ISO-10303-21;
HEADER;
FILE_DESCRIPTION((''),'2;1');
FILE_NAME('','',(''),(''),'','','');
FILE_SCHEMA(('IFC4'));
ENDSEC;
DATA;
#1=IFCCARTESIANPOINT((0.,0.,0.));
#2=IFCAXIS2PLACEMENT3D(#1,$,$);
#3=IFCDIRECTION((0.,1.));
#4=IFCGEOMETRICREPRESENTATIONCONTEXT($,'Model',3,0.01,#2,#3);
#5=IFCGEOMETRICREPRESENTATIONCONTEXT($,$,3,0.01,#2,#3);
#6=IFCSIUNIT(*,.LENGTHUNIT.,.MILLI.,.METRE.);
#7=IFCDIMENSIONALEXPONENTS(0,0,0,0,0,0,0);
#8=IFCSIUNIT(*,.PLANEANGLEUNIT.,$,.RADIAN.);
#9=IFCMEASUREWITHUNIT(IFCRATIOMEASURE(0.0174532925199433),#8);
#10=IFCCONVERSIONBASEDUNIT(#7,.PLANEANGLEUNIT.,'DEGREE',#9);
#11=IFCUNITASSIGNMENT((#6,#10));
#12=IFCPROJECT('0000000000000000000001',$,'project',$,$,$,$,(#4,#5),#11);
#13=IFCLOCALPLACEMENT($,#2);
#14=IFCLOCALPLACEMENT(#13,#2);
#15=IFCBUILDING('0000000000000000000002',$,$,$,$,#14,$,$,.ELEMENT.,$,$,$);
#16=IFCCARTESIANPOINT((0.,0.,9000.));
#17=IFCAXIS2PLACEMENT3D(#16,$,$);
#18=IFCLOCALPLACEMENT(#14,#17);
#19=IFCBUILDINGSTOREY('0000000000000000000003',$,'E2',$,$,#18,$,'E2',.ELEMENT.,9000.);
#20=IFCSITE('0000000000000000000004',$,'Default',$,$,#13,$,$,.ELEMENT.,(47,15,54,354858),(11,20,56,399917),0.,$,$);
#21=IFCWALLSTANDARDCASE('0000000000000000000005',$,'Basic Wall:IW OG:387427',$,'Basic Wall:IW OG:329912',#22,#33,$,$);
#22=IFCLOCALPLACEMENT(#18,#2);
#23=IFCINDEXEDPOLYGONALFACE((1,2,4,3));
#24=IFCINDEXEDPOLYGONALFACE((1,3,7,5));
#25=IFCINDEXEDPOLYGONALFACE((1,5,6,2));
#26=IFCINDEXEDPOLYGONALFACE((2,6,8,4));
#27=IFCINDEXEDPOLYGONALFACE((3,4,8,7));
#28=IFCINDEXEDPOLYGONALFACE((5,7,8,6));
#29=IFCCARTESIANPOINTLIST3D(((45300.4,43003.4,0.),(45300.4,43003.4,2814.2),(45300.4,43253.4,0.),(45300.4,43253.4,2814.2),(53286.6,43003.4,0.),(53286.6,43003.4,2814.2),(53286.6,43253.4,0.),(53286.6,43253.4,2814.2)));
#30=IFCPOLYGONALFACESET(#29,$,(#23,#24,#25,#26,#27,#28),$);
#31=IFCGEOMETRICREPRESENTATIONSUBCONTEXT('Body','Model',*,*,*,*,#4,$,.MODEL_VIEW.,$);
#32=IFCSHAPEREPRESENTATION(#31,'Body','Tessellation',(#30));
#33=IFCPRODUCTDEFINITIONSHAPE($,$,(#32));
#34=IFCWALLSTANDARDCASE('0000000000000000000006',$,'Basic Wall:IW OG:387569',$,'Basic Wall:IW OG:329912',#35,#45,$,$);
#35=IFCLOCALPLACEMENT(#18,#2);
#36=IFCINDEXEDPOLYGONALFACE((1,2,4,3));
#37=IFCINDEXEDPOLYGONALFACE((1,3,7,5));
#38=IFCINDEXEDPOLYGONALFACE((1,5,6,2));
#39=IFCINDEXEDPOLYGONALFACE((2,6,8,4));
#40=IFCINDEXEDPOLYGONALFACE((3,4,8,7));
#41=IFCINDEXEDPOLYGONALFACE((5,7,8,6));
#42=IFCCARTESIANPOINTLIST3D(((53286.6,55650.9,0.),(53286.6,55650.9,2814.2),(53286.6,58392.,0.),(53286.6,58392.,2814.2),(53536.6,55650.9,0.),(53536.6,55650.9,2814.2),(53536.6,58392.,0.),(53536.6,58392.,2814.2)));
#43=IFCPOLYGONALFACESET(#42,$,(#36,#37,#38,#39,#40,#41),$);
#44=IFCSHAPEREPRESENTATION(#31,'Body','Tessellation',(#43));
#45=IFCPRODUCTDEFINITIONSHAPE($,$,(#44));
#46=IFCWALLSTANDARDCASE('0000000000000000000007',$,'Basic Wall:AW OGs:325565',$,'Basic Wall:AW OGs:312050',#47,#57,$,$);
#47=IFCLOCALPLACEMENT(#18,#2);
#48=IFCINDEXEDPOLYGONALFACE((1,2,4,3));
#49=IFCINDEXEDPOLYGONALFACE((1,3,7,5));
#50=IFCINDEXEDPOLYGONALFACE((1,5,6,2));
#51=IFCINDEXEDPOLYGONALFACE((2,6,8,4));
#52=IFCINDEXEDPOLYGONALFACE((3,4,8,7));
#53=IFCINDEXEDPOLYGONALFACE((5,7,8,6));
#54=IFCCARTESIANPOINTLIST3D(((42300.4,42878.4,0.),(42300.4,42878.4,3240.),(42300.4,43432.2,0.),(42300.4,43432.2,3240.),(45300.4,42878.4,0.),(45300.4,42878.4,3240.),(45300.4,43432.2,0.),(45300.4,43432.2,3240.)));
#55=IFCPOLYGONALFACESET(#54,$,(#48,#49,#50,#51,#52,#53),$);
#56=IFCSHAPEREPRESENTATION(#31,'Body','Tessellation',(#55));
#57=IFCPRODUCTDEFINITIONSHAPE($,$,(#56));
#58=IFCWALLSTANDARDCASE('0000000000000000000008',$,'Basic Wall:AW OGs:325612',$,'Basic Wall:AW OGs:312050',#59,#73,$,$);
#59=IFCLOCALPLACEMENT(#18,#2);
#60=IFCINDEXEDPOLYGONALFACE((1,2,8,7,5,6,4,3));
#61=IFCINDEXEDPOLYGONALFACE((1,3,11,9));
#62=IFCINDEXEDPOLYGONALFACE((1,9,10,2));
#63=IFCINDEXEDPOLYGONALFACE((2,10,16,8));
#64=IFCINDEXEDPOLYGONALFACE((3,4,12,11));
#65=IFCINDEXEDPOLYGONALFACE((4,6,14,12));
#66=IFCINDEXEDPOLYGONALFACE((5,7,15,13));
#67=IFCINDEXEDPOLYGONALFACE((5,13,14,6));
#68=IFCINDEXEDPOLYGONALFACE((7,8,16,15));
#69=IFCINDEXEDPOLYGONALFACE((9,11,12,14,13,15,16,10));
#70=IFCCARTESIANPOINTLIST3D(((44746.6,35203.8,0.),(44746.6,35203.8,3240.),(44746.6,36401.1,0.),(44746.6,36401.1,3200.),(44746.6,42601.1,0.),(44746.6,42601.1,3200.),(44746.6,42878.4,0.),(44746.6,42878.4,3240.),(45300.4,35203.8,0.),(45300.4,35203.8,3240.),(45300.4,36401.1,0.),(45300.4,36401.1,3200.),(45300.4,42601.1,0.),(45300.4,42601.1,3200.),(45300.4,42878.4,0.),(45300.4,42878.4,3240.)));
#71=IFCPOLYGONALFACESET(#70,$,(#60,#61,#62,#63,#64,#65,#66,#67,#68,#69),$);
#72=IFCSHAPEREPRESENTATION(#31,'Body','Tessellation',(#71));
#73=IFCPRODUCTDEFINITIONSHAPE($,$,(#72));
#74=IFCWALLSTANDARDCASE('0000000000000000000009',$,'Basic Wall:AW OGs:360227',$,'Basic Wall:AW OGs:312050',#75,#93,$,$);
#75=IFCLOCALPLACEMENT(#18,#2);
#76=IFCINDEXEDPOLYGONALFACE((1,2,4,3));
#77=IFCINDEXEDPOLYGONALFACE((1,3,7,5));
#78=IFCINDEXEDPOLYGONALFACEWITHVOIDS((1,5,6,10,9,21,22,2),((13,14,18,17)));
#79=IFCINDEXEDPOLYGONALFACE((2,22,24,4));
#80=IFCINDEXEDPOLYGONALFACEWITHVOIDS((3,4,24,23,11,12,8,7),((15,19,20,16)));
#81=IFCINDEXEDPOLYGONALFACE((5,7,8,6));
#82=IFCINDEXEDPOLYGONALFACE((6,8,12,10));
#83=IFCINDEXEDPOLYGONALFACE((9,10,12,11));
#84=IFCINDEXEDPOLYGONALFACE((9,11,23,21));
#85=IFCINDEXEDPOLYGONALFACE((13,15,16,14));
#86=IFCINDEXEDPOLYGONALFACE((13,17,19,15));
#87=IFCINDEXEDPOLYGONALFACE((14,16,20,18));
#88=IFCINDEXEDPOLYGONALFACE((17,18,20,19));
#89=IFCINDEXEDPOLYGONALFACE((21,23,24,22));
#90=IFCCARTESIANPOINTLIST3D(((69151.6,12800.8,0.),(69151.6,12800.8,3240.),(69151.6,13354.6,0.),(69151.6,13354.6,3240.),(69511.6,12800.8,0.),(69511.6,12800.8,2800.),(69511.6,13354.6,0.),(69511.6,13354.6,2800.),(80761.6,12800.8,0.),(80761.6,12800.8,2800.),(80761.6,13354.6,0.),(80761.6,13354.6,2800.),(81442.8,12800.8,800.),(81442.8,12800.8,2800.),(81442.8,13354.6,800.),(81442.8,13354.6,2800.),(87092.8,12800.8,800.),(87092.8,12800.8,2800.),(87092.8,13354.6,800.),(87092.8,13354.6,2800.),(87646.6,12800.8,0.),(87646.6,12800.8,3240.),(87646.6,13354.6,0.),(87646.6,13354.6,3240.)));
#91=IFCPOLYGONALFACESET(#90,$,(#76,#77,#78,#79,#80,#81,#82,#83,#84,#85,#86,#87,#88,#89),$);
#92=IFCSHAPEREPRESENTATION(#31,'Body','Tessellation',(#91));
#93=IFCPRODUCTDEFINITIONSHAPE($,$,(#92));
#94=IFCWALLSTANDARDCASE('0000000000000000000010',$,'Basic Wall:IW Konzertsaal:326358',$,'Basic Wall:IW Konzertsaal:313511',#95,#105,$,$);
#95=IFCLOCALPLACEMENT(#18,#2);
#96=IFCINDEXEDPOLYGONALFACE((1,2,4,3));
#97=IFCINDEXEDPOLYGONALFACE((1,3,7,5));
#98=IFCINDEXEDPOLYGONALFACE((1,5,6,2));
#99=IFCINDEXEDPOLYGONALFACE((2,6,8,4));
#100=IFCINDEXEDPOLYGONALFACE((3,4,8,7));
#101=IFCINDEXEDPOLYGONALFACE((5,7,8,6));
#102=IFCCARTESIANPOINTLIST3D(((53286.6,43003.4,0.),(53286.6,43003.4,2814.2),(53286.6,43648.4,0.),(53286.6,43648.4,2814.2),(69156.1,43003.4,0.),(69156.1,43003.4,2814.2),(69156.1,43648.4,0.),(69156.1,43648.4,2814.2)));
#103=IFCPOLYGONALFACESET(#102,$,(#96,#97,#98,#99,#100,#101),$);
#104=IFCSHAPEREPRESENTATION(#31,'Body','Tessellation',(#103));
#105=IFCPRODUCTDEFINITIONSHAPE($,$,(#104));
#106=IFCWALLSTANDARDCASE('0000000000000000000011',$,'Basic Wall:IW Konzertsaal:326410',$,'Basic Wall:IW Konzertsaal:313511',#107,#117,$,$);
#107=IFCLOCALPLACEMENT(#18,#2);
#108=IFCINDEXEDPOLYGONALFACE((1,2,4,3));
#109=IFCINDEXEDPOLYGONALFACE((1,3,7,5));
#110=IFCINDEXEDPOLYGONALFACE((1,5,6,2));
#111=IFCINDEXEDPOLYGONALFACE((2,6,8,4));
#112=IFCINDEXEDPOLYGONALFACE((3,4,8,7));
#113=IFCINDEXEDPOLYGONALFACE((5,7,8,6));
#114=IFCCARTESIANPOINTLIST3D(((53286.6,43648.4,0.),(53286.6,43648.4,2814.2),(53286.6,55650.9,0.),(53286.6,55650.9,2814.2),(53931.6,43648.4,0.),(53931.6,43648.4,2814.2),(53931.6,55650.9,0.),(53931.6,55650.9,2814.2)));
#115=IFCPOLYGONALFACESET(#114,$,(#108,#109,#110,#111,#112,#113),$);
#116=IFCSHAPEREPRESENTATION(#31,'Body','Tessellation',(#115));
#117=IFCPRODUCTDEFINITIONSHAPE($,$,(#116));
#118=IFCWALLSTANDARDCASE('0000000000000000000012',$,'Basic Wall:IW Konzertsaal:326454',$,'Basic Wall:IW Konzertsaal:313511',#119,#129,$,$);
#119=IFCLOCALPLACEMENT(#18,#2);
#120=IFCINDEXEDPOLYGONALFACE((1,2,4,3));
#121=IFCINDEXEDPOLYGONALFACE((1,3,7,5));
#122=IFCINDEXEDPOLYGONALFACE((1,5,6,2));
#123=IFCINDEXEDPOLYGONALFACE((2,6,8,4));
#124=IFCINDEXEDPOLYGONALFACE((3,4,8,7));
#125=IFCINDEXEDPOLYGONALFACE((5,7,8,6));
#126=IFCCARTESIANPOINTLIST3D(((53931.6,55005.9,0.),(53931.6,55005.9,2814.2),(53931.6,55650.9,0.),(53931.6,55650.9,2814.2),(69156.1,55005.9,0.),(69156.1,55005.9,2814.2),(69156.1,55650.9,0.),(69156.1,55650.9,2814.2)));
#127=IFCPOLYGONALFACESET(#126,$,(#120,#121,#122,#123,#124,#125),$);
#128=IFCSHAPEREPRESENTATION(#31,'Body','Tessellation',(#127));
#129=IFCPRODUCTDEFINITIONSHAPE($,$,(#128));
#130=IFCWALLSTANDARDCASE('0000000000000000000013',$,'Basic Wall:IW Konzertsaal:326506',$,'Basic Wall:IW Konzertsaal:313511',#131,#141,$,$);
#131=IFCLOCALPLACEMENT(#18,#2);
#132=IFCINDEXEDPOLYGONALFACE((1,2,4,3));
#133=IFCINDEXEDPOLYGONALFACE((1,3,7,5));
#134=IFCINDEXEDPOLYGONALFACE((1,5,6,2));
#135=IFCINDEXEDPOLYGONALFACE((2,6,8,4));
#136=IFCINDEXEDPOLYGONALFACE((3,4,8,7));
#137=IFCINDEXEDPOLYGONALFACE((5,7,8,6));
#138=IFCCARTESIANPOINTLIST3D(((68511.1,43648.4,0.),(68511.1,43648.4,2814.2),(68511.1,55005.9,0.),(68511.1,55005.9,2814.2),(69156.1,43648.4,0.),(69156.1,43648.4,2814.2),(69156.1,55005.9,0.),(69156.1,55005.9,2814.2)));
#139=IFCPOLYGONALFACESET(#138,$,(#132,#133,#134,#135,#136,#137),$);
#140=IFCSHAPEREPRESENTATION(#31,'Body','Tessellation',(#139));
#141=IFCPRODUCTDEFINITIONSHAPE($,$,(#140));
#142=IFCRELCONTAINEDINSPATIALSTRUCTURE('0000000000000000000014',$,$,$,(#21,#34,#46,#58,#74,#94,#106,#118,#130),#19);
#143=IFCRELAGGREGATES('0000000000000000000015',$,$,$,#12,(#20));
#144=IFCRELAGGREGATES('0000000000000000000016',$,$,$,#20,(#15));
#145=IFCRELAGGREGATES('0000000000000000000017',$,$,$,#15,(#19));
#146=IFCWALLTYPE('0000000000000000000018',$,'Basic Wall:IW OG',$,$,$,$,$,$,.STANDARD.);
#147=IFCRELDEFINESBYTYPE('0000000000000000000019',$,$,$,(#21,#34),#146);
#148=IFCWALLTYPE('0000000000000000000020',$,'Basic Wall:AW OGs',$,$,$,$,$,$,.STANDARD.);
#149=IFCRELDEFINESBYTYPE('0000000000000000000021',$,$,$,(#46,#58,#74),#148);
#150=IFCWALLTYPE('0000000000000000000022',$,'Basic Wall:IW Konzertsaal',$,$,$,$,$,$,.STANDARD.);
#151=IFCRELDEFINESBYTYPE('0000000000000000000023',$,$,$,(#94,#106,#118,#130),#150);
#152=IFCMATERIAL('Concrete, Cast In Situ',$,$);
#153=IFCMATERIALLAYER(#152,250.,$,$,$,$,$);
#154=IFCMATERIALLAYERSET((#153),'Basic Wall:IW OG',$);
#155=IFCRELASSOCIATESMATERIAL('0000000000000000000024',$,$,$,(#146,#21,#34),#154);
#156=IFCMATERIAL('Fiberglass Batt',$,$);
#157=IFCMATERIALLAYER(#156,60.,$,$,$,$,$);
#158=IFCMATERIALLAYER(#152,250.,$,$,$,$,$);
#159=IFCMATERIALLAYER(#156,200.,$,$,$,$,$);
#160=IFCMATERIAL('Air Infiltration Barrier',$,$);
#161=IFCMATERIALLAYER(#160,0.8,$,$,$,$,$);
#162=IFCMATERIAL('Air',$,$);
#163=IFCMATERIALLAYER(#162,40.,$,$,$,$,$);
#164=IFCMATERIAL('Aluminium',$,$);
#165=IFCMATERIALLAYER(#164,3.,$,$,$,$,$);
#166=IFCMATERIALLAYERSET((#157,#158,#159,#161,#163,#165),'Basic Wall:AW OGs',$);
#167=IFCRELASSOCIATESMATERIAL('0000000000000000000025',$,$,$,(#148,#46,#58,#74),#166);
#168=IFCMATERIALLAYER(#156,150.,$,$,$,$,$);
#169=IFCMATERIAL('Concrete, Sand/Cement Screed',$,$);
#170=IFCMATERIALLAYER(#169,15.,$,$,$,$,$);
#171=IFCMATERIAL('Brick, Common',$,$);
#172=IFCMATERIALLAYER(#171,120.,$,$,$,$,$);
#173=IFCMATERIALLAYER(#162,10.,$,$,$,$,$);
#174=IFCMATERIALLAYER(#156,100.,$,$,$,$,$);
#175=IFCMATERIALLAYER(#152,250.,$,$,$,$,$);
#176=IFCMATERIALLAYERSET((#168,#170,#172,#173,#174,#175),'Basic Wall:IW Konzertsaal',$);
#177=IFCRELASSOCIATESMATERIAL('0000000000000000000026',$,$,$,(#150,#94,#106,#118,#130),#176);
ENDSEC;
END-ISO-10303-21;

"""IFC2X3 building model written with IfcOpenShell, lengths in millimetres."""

from ifc_helpers import new_model, entity, si_unit, converted_unit, direction, frame, frame_2d, origin, place, context, subcontext, project, spatial, polyline, rectangle, extrude, clip, bounded_halfspace, material, layer, layer_set, layer_usage, type_object, element, save


model = new_model("IFC2X3")

# Units and contexts
model_context = context("Model", 3, precision=0.01, world=origin(), true_north=direction((0.0, 1.0)))
context_of_model = context(None, 3, precision=0.01, world=origin(), true_north=direction((0.0, 1.0)))
body_context = subcontext(model_context, "Body", "Model", "MODEL_VIEW")
ifc_project = project(units=[si_unit("LENGTHUNIT", "METRE", prefix="MILLI"), converted_unit("PLANEANGLEUNIT", "DEGREE", entity("IfcRatioMeasure", 0.0174532925199433), si_unit("PLANEANGLEUNIT", "RADIAN"), dimensions=[0, 0, 0, 0, 0, 0, 0])], contexts=[model_context, context_of_model])

# Site, building, storey
site_placement = place(None, origin())
site = spatial("IfcSite", under=ifc_project, at=site_placement, Name="Default", CompositionType="ELEMENT", RefLatitude=(47, 15, 54, 354858), RefLongitude=(11, 20, 56, 399917), RefElevation=0.0)
building_placement = place(site_placement, origin())
building = spatial("IfcBuilding", under=site, at=building_placement, CompositionType="ELEMENT")
storey_placement = place(building_placement, frame((0.0, 0.0, 9000.0)))
storey = spatial("IfcBuildingStorey", under=building, at=storey_placement, Name="E2", LongName="E2", CompositionType="ELEMENT", Elevation=9000.0)

# Shared definitions
ifc_material_1 = material(Name="Concrete, Sand/Cement Screed")
ifc_material_2 = material(Name="Air Infiltration Barrier")
ifc_material_3 = material(Name="Fiberglass Batt")

# Walls
ifc_material_4 = material(Name="Concrete, Cast In Situ")
ifc_layer_1 = layer(ifc_material_4, 250.0)
ifc_layer_set_1 = layer_set([ifc_layer_1], Name="Basic Wall:IW OG")
ifc_layer_usage_1 = layer_usage(ifc_layer_set_1, "AXIS2", "NEGATIVE", 125.0)
wall_type_1 = type_object("IfcWallType", Name="Basic Wall:IW OG", PredefinedType="STANDARD", material=ifc_layer_set_1)
wall_1_placement = place(storey_placement, frame((53286.6, 43128.4, 0.0), z_axis=(0.0, 0.0, 1.0), x_axis=(-1.0, 0.0, 0.0)))
element("IfcWallStandardCase", 1, at=wall_1_placement, inside=storey, type_object=wall_type_1, material=ifc_layer_usage_1, Name="Basic Wall:IW OG:387427", ObjectType="Basic Wall:IW OG:329912", context=body_context, shape_type="Clipping", body=[
    clip(extrude(rectangle(XDim=7986.2, YDim=250.0, at=frame_2d((3993.1, 0.0), x_axis=(-1.0, 0.0))), origin(), (0.0, 0.0, 1.0), 2814.2), bounded_halfspace(frame((0.0, -125.0, 2814.2), z_axis=(0.0, 0.0, -1.0), x_axis=(-1.0, 0.0, 0.0)), True, frame((0.0, -125.0, 2814.2)), polyline([(0.0, 0.0), (7986.2, 0.0), (7986.2, 250.0), (0.0, 250.0), (0.0, 0.0)]))),
])
ifc_layer_usage_2 = layer_usage(ifc_layer_set_1, "AXIS2", "NEGATIVE", 125.0)
wall_2_placement = place(storey_placement, frame((53411.6, 55650.9, 0.0), z_axis=(0.0, 0.0, 1.0), x_axis=(0.0, 1.0, 0.0)))
element("IfcWallStandardCase", 2, at=wall_2_placement, inside=storey, type_object=wall_type_1, material=ifc_layer_usage_2, Name="Basic Wall:IW OG:387569", ObjectType="Basic Wall:IW OG:329912", context=body_context, shape_type="Clipping", body=[
    clip(extrude(rectangle(XDim=2741.2, YDim=250.0, at=frame_2d((1370.6, 0.0), x_axis=(-1.0, 0.0))), origin(), (0.0, 0.0, 1.0), 2814.2), bounded_halfspace(frame((0.0, -125.0, 2814.2), z_axis=(0.0, 0.0, -1.0), x_axis=(0.0, -1.0, 0.0)), True, frame((0.0, -125.0, 2814.2)), polyline([(0.0, 0.0), (2741.2, 0.0), (2741.2, 250.0), (0.0, 250.0), (0.0, 0.0)]))),
])

# Shared definitions
ifc_layer_2 = layer(ifc_material_3, 60.0)
ifc_layer_3 = layer(ifc_material_4, 250.0)
ifc_layer_4 = layer(ifc_material_3, 200.0)
ifc_layer_5 = layer(ifc_material_2, 0.8)
ifc_material_5 = material(Name="Air")
ifc_layer_6 = layer(ifc_material_5, 40.0)
ifc_material_6 = material(Name="Aluminium")
ifc_layer_7 = layer(ifc_material_6, 3.0)
ifc_layer_set_2 = layer_set([ifc_layer_2, ifc_layer_3, ifc_layer_4, ifc_layer_5, ifc_layer_6, ifc_layer_7], Name="Basic Wall:AW OGs")
wall_type_2 = type_object("IfcWallType", Name="Basic Wall:AW OGs", PredefinedType="STANDARD", material=ifc_layer_set_2)

# Wall
ifc_layer_usage_3 = layer_usage(ifc_layer_set_2, "AXIS2", "NEGATIVE", 276.9)
wall_3_placement = place(storey_placement, frame((42300.4, 43155.3, 0.0)))
element("IfcWallStandardCase", 3, at=wall_3_placement, inside=storey, type_object=wall_type_2, material=ifc_layer_usage_3, Name="Basic Wall:AW OGs:325565", ObjectType="Basic Wall:AW OGs:312050", context=body_context, shape_type="SweptSolid", body=[
    extrude(rectangle(XDim=3000.0, YDim=553.8, at=frame_2d((1500.0, 0.0), x_axis=(-1.0, 0.0))), origin(), (0.0, 0.0, 1.0), 3240.0),
])

# Wall, opening
ifc_layer_usage_4 = layer_usage(ifc_layer_set_2, "AXIS2", "NEGATIVE", 276.9)
wall_4_placement = place(storey_placement, frame((45023.5, 42878.4, 0.0), z_axis=(0.0, 0.0, 1.0), x_axis=(0.0, -1.0, 0.0)))
wall_4 = element("IfcWallStandardCase", 4, at=wall_4_placement, inside=storey, type_object=wall_type_2, material=ifc_layer_usage_4, Name="Basic Wall:AW OGs:325612", ObjectType="Basic Wall:AW OGs:312050", context=body_context, shape_type="SweptSolid", body=[
    extrude(rectangle(XDim=7674.7, YDim=553.8, at=frame_2d((3837.3, 0.0), x_axis=(-1.0, 0.0))), origin(), (0.0, 0.0, 1.0), 3240.0),
])
opening_1_placement = place(wall_4_placement, frame((6477.3, 276.9, 0.0)))
element("IfcOpeningElement", 5, at=opening_1_placement, cuts=wall_4, ObjectType="Opening", context=body_context, shape_type="SweptSolid", body=[
    extrude(rectangle(XDim=3200.0, YDim=6200.0, at=frame_2d((1600.0, 3100.0), x_axis=(-1.0, 0.0))), frame((0.0, 0.0, 0.0), z_axis=(0.0, -1.0, 0.0), x_axis=(0.0, 0.0, 1.0)), (0.0, 0.0, 1.0), 553.8),
])

# Wall, openings
ifc_layer_usage_5 = layer_usage(ifc_layer_set_2, "AXIS2", "NEGATIVE", 276.9)
wall_5_placement = place(storey_placement, frame((69151.6, 13077.7, 0.0)))
wall_5 = element("IfcWallStandardCase", 6, at=wall_5_placement, inside=storey, type_object=wall_type_2, material=ifc_layer_usage_5, Name="Basic Wall:AW OGs:360227", ObjectType="Basic Wall:AW OGs:312050", context=body_context, shape_type="SweptSolid", body=[
    extrude(rectangle(XDim=18495.0, YDim=553.8, at=frame_2d((9247.5, 0.0), x_axis=(-1.0, 0.0))), origin(), (0.0, 0.0, 1.0), 3240.0),
])
opening_2_placement = place(wall_5_placement, origin())
element("IfcOpeningElement", 7, at=opening_2_placement, cuts=wall_5, ObjectType="Opening", context=body_context, shape_type="SweptSolid", body=[
    extrude(rectangle(XDim=2400.0, YDim=553.8, at=frame_2d((0.0, 0.0), x_axis=(0.0, 1.0))), frame((18218.1, 276.9, 1700.0), z_axis=(0.0, 1.0, 0.0), x_axis=(1.0, 0.0, 0.0)), (0.0, 0.0, 1.0), 6800.0),
])
opening_3_placement = place(wall_5_placement, frame((11610.0, 276.9, 0.0)))
element("IfcOpeningElement", 8, at=opening_3_placement, cuts=wall_5, ObjectType="Opening", context=body_context, shape_type="SweptSolid", body=[
    extrude(rectangle(XDim=2800.0, YDim=11250.0, at=frame_2d((1400.0, 5625.0), x_axis=(-1.0, 0.0))), frame((0.0, 0.0, 0.0), z_axis=(0.0, -1.0, 0.0), x_axis=(0.0, 0.0, 1.0)), (0.0, 0.0, 1.0), 553.8),
])
opening_4_placement = place(wall_5_placement, frame((17941.2, 276.9, 800.0)))
element("IfcOpeningElement", 9, at=opening_4_placement, cuts=wall_5, ObjectType="Opening", context=body_context, shape_type="SweptSolid", body=[
    extrude(rectangle(XDim=2000.0, YDim=5650.0, at=frame_2d((1000.0, 2825.0), x_axis=(-1.0, 0.0))), frame((0.0, 0.0, 0.0), z_axis=(0.0, -1.0, 0.0), x_axis=(0.0, 0.0, 1.0)), (0.0, 0.0, 1.0), 553.8),
])

# Walls
ifc_layer_8 = layer(ifc_material_3, 150.0)
ifc_layer_9 = layer(ifc_material_1, 15.0)
ifc_material_7 = material(Name="Brick, Common")
ifc_layer_10 = layer(ifc_material_7, 120.0)
ifc_layer_11 = layer(ifc_material_5, 10.0)
ifc_layer_12 = layer(ifc_material_3, 100.0)
ifc_layer_13 = layer(ifc_material_4, 250.0)
ifc_layer_set_3 = layer_set([ifc_layer_8, ifc_layer_9, ifc_layer_10, ifc_layer_11, ifc_layer_12, ifc_layer_13], Name="Basic Wall:IW Konzertsaal")
ifc_layer_usage_6 = layer_usage(ifc_layer_set_3, "AXIS2", "POSITIVE", -322.5)
wall_type_3 = type_object("IfcWallType", Name="Basic Wall:IW Konzertsaal", PredefinedType="STANDARD", material=ifc_layer_set_3)
wall_6_placement = place(storey_placement, frame((69156.1, 43325.9, 0.0), z_axis=(0.0, 0.0, 1.0), x_axis=(-1.0, 0.0, 0.0)))
element("IfcWallStandardCase", 10, at=wall_6_placement, inside=storey, type_object=wall_type_3, material=ifc_layer_usage_6, Name="Basic Wall:IW Konzertsaal:326358", ObjectType="Basic Wall:IW Konzertsaal:313511", context=body_context, shape_type="Clipping", body=[
    clip(extrude(rectangle(XDim=15869.5, YDim=645.0, at=frame_2d((7934.8, 0.0), x_axis=(-1.0, 0.0))), origin(), (0.0, 0.0, 1.0), 2814.2), bounded_halfspace(frame((0.0, -322.5, 2814.2), z_axis=(0.0, 0.0, -1.0), x_axis=(-1.0, 0.0, 0.0)), True, frame((0.0, -322.5, 2814.2)), polyline([(0.0, 0.0), (645.0, 0.0), (15224.5, 0.0), (15869.5, 0.0), (15869.5, 395.0), (15869.5, 645.0), (4.5, 645.0), (0.0, 645.0), (0.0, 0.0)]))),
])
ifc_layer_usage_7 = layer_usage(ifc_layer_set_3, "AXIS2", "POSITIVE", -322.5)
wall_7_placement = place(storey_placement, frame((53609.1, 43648.4, 0.0), z_axis=(0.0, 0.0, 1.0), x_axis=(0.0, 1.0, 0.0)))
element("IfcWallStandardCase", 11, at=wall_7_placement, inside=storey, type_object=wall_type_3, material=ifc_layer_usage_7, Name="Basic Wall:IW Konzertsaal:326410", ObjectType="Basic Wall:IW Konzertsaal:313511", context=body_context, shape_type="Clipping", body=[
    clip(extrude(rectangle(XDim=12002.4, YDim=645.0, at=frame_2d((6001.2, 0.0), x_axis=(-1.0, 0.0))), origin(), (0.0, 0.0, 1.0), 2814.2), bounded_halfspace(frame((0.0, -322.5, 2814.2), z_axis=(0.0, 0.0, -1.0), x_axis=(0.0, -1.0, 0.0)), True, frame((0.0, -322.5, 2814.2)), polyline([(0.0, 0.0), (11357.4, 0.0), (12002.4, 0.0), (12002.4, 395.0), (12002.4, 645.0), (0.0, 645.0), (0.0, 0.0)]))),
])
ifc_layer_usage_8 = layer_usage(ifc_layer_set_3, "AXIS2", "POSITIVE", -322.5)
wall_8_placement = place(storey_placement, frame((53931.6, 55328.4, 0.0)))
element("IfcWallStandardCase", 12, at=wall_8_placement, inside=storey, type_object=wall_type_3, material=ifc_layer_usage_8, Name="Basic Wall:IW Konzertsaal:326454", ObjectType="Basic Wall:IW Konzertsaal:313511", context=body_context, shape_type="Clipping", body=[
    clip(extrude(rectangle(XDim=15224.5, YDim=645.0, at=frame_2d((7612.3, 0.0), x_axis=(-1.0, 0.0))), origin(), (0.0, 0.0, 1.0), 2814.2), bounded_halfspace(frame((0.0, -322.5, 2814.2), z_axis=(0.0, 0.0, -1.0), x_axis=(1.0, 0.0, 0.0)), True, frame((0.0, -322.5, 2814.2)), polyline([(0.0, 0.0), (14579.5, 0.0), (15224.5, 0.0), (15224.5, 645.0), (0.0, 645.0), (0.0, 0.0)]))),
])
ifc_layer_usage_9 = layer_usage(ifc_layer_set_3, "AXIS2", "POSITIVE", -322.5)
wall_9_placement = place(storey_placement, frame((68833.6, 55005.9, 0.0), z_axis=(0.0, 0.0, 1.0), x_axis=(0.0, -1.0, 0.0)))
element("IfcWallStandardCase", 13, at=wall_9_placement, inside=storey, type_object=wall_type_3, material=ifc_layer_usage_9, Name="Basic Wall:IW Konzertsaal:326506", ObjectType="Basic Wall:IW Konzertsaal:313511", context=body_context, shape_type="Clipping", body=[
    clip(extrude(rectangle(XDim=11357.4, YDim=645.0, at=frame_2d((5678.7, 0.0), x_axis=(-1.0, 0.0))), origin(), (0.0, 0.0, 1.0), 2814.2), bounded_halfspace(frame((0.0, -322.5, 2814.2), z_axis=(0.0, 0.0, -1.0), x_axis=(0.0, 1.0, 0.0)), True, frame((0.0, -322.5, 2814.2)), polyline([(0.0, 0.0), (11357.4, 0.0), (11357.4, 645.0), (0.0, 645.0), (0.0, 0.0)]))),
])

save(model, "model.ifc")
